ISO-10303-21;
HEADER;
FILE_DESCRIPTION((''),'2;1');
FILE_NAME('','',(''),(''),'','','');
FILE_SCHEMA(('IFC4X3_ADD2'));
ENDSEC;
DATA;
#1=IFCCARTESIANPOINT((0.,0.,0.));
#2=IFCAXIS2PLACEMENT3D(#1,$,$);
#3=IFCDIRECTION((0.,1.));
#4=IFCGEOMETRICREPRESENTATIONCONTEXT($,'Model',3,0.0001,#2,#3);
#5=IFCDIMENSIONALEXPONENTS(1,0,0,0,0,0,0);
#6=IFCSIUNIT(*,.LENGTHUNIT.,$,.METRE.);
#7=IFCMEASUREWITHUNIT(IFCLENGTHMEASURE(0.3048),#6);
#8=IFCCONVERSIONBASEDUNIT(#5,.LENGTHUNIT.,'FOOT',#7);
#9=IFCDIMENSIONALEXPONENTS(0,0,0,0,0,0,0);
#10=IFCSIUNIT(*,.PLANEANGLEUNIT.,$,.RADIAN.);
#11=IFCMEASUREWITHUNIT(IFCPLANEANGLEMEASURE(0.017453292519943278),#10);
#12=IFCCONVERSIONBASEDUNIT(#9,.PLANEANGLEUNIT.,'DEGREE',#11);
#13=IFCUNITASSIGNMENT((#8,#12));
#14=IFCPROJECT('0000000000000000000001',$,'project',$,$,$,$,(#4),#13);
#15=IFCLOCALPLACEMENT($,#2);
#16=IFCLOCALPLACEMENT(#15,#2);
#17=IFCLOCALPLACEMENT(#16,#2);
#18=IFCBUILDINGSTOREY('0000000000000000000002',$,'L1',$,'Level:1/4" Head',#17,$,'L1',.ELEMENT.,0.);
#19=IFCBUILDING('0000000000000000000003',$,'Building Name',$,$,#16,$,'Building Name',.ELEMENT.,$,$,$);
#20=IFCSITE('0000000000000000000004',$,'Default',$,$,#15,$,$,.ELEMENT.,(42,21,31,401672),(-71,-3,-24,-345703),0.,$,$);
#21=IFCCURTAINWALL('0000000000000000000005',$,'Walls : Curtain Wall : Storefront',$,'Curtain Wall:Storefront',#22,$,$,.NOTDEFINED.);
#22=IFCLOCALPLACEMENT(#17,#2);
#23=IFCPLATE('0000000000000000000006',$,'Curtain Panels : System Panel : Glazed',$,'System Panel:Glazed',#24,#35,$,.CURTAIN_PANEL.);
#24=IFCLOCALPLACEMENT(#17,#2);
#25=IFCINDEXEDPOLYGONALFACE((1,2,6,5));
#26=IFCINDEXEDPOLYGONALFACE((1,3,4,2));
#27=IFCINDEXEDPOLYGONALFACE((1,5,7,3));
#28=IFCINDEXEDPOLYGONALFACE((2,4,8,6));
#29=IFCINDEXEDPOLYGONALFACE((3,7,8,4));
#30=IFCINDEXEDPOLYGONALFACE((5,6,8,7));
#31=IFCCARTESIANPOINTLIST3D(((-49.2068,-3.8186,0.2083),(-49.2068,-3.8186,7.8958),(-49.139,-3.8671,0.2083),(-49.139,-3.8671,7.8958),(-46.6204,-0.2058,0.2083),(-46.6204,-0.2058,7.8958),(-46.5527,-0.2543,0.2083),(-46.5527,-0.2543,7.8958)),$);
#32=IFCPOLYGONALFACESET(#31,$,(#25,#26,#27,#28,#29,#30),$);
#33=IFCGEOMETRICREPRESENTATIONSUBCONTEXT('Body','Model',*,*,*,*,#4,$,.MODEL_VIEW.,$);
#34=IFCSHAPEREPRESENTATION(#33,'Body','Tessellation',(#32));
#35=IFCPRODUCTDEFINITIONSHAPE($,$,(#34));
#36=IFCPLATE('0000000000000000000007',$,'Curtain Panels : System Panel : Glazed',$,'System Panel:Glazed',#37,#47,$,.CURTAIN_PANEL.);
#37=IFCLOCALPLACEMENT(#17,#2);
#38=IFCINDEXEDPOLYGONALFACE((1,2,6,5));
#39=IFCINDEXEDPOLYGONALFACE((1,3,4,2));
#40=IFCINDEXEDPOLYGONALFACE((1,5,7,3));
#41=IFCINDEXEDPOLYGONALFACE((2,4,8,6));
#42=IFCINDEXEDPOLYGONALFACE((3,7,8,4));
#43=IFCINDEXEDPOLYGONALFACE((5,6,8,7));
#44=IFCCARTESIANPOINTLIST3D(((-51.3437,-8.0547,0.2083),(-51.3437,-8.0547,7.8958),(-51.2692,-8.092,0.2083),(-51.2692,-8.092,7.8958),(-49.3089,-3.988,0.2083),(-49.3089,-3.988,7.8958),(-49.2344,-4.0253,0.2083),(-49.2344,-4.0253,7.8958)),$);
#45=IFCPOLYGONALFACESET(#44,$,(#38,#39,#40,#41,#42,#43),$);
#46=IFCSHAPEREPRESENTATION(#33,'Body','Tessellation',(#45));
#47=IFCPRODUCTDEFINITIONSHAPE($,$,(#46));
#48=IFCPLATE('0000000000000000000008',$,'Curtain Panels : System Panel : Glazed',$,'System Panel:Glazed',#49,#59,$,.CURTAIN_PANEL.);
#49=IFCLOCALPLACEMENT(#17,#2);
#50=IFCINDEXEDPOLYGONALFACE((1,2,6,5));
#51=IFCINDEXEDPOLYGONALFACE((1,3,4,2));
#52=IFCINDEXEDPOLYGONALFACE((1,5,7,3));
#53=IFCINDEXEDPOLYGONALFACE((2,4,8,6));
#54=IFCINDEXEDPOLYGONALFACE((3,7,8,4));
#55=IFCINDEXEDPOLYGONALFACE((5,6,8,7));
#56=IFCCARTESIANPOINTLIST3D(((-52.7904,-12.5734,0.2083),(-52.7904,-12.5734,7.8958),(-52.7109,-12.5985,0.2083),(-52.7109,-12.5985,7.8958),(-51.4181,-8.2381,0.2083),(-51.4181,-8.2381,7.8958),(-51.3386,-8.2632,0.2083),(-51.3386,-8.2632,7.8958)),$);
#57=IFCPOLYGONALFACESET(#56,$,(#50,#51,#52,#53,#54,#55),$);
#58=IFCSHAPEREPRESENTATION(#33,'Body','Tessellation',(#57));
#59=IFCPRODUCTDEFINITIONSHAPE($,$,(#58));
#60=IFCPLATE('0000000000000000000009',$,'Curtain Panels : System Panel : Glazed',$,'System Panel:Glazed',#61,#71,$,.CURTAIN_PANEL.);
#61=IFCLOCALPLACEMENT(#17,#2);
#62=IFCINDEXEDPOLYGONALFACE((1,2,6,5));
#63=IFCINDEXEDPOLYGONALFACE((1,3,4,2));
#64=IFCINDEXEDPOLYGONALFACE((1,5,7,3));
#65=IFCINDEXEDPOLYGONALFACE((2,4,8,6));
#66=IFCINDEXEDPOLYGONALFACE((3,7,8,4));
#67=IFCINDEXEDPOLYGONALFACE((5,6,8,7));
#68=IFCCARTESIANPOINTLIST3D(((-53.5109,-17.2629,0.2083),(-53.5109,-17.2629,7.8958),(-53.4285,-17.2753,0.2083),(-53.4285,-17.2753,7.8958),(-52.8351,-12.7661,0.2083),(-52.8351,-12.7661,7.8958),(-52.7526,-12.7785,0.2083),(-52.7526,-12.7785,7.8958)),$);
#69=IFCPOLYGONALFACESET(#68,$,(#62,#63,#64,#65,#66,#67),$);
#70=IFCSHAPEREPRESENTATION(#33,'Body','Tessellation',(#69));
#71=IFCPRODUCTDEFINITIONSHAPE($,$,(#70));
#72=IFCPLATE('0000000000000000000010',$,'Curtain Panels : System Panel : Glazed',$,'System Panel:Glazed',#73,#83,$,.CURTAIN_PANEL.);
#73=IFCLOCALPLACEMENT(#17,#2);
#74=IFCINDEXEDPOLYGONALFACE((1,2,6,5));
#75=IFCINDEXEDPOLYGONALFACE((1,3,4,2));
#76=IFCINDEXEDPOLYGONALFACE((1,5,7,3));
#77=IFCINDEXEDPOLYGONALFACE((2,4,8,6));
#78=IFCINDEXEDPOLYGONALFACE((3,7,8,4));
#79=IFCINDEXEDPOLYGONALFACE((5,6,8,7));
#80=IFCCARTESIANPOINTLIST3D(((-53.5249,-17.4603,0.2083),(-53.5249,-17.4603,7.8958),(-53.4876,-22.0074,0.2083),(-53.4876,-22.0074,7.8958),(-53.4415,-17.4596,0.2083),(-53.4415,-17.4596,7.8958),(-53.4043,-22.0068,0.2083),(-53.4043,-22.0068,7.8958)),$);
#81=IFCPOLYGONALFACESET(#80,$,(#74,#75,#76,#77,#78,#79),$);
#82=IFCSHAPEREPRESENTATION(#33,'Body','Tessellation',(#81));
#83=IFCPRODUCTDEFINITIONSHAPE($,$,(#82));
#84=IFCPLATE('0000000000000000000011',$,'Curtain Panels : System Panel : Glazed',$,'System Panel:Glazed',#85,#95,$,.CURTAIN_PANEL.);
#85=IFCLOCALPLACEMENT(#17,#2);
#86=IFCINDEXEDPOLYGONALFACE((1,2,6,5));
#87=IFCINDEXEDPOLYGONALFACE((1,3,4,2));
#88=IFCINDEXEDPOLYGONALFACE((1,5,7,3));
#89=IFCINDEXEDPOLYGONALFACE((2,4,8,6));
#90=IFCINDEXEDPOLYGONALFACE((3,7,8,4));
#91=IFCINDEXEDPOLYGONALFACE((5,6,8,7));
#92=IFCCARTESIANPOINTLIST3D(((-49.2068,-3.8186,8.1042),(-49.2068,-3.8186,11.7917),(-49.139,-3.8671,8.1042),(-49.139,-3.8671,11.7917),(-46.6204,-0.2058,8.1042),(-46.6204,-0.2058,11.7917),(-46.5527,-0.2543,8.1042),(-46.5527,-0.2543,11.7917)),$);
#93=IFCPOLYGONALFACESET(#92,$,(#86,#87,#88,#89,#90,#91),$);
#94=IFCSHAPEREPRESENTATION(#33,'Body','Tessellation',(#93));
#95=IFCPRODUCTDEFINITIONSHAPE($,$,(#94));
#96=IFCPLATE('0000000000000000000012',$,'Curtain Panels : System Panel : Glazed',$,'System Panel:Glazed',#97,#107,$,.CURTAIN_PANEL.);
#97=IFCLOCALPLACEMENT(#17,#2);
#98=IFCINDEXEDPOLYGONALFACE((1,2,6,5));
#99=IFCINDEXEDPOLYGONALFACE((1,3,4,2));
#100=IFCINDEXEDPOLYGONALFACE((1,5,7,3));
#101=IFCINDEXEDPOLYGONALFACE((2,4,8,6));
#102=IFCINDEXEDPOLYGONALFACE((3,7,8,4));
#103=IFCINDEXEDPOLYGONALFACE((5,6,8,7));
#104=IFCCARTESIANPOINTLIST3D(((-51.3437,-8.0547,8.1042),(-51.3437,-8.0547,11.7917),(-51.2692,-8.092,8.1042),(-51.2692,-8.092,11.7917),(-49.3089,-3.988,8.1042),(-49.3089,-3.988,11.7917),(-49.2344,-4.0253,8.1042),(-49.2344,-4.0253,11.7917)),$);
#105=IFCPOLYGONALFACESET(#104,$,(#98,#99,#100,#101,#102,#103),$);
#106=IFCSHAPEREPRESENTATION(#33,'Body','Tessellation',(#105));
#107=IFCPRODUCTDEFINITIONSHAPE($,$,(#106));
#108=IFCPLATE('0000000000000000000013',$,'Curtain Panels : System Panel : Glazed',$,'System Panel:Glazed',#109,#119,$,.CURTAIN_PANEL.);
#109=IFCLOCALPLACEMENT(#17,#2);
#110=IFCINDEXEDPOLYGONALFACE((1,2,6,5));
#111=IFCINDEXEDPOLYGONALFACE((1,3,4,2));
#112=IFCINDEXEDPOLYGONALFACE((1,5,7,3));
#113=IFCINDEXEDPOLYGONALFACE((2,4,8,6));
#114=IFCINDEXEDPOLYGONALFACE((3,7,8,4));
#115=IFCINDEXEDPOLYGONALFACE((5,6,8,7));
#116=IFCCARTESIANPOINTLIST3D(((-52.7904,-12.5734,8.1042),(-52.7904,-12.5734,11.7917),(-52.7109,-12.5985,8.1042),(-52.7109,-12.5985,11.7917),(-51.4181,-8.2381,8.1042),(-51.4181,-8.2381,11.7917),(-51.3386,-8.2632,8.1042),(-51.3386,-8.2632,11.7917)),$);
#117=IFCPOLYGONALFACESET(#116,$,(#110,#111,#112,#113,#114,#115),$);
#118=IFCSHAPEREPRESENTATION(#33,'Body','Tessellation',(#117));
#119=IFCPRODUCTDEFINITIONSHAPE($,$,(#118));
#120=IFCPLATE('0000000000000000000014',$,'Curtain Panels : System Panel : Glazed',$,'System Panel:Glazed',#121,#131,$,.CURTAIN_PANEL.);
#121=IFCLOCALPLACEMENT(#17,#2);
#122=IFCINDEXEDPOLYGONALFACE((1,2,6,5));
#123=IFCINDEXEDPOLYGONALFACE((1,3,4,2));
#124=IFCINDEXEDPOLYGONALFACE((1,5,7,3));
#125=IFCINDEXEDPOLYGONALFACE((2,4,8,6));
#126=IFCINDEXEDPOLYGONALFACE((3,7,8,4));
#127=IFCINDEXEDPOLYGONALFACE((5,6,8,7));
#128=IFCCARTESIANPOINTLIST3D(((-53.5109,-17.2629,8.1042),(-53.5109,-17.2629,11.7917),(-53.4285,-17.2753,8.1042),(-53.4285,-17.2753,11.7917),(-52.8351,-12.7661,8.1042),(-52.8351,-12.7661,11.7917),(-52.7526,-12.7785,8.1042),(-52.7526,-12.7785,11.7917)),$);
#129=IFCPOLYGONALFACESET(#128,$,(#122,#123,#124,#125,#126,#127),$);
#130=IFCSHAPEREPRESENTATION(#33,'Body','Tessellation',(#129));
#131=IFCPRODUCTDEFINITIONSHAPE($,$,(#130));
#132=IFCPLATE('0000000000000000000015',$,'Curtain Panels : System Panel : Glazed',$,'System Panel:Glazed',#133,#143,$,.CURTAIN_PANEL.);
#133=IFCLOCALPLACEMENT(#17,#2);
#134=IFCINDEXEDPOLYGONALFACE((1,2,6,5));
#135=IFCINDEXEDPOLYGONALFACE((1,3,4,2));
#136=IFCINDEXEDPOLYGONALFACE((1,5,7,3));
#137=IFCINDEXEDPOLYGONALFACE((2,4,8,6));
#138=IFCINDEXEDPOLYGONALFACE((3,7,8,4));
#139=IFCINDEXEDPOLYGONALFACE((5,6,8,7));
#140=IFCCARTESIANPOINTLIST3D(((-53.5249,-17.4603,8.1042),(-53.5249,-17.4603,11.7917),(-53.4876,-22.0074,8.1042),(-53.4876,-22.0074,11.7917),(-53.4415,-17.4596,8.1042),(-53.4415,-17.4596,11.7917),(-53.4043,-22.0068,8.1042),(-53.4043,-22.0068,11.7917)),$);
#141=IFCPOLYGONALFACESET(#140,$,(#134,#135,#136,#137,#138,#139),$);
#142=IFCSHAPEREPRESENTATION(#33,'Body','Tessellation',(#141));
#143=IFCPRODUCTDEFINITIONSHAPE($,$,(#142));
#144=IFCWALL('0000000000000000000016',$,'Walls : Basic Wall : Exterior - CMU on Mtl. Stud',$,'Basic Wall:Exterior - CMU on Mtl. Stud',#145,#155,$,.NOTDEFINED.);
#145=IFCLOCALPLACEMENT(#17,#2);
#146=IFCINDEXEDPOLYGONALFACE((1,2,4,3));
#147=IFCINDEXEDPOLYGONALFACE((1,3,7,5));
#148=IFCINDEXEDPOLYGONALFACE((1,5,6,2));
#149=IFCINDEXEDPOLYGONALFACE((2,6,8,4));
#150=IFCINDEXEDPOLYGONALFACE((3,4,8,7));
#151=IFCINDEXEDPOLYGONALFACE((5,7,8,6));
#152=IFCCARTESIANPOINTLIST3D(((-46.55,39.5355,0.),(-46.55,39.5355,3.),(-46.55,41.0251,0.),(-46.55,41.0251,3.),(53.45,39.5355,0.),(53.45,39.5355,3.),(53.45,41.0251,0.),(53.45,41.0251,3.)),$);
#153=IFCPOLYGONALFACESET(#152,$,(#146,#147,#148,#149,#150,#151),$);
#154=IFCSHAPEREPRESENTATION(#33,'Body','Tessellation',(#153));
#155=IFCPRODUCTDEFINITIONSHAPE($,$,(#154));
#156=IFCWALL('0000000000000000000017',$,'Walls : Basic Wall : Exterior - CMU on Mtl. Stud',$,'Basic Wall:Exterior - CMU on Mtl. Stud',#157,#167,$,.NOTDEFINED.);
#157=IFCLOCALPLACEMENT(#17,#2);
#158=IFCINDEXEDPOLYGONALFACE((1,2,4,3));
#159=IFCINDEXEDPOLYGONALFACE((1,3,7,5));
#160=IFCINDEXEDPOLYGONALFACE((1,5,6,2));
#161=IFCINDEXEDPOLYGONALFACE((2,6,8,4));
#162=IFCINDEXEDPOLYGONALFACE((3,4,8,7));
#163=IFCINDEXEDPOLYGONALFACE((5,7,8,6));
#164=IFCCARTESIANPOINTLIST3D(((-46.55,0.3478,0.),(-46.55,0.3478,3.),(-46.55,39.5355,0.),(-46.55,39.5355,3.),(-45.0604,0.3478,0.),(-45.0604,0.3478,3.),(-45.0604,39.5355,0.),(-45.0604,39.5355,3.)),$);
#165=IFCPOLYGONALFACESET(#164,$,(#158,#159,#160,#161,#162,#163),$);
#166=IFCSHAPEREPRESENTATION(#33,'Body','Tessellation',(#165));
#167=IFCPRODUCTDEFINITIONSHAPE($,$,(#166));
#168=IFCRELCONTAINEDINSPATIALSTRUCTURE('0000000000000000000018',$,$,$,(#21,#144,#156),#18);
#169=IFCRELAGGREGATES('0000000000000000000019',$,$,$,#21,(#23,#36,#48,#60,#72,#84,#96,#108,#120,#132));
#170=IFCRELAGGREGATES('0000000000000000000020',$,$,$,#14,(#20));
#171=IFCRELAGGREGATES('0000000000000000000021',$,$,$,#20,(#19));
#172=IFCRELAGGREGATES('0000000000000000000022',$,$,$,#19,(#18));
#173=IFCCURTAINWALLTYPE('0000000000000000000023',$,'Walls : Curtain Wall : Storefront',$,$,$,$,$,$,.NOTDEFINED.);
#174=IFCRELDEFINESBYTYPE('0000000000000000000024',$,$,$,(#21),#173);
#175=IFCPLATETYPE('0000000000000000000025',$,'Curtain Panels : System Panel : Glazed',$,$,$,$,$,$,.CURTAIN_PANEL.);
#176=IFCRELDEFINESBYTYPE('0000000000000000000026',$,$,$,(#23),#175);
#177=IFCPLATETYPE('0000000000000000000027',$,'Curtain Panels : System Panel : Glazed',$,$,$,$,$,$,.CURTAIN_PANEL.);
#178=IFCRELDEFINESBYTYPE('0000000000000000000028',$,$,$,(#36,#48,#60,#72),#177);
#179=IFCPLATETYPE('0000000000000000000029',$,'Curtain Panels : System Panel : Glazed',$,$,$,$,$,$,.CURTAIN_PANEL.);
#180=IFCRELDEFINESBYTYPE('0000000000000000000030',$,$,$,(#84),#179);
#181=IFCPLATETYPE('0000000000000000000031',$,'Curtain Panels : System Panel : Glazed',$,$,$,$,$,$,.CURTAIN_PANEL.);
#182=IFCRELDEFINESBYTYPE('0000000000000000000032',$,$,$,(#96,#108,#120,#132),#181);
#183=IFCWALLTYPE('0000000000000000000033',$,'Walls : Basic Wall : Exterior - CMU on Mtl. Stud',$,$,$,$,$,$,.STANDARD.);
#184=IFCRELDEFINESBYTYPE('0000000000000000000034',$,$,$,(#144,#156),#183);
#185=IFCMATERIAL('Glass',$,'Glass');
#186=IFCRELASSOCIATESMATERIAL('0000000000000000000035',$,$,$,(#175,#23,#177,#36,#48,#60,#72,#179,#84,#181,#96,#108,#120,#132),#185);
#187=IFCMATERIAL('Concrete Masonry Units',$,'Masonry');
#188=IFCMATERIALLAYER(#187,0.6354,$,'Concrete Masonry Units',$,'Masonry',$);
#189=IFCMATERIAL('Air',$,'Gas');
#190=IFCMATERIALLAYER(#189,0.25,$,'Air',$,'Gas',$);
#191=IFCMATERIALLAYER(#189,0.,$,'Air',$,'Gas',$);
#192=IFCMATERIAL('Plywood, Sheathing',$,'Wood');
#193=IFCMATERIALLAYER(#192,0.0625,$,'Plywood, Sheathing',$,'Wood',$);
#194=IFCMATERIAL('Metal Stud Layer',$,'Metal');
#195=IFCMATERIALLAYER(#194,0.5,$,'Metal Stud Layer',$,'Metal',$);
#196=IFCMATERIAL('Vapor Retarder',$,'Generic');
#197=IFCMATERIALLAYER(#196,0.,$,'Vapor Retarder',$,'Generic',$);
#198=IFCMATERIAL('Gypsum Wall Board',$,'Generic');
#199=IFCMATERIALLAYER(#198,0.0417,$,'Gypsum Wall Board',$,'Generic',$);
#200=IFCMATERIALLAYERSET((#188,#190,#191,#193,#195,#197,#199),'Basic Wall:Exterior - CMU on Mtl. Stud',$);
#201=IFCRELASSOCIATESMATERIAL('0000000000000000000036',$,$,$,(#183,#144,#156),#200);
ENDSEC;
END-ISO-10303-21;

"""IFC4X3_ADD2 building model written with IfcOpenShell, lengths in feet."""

from ifc_helpers import new_model, entity, si_unit, converted_unit, direction, frame, frame_2d, origin, place, context, subcontext, project, spatial, rectangle, extrude, source, transform, mapped, material, layer, layer_set, type_object, type_shapes, element, aggregate, save


model = new_model("IFC4X3_ADD2")

# Units and contexts
model_context = context("Model", 3, precision=0.0001, world=origin(), true_north=direction((0.0, 1.0)))
body_context = subcontext(model_context, "Body", "Model", "MODEL_VIEW")
ifc_project = project(units=[converted_unit("LENGTHUNIT", "FOOT", entity("IfcLengthMeasure", 0.3048), si_unit("LENGTHUNIT", "METRE"), dimensions=[1, 0, 0, 0, 0, 0, 0]), converted_unit("PLANEANGLEUNIT", "DEGREE", entity("IfcPlaneAngleMeasure", 0.017453292519943278), si_unit("PLANEANGLEUNIT", "RADIAN"), dimensions=[0, 0, 0, 0, 0, 0, 0])], contexts=[model_context])

# Site, building, storey
site_placement = place(None, origin())
site = spatial("IfcSite", under=ifc_project, at=site_placement, Name="Default", CompositionType="ELEMENT", RefLatitude=(42, 21, 31, 401672), RefLongitude=(-71, -3, -24, -345703), RefElevation=0.0)
building_placement = place(site_placement, origin())
building = spatial("IfcBuilding", under=site, at=building_placement, Name="Building Name", LongName="Building Name", CompositionType="ELEMENT")
storey_placement = place(building_placement, origin())
storey = spatial("IfcBuildingStorey", under=building, at=storey_placement, Name="L1", ObjectType="Level:1/4\" Head", LongName="L1", CompositionType="ELEMENT", Elevation=0.0)

# Curtain wall, plates
curtain_wall_type = type_object("IfcCurtainWallType", Name="Walls : Curtain Wall : Storefront", PredefinedType="NOTDEFINED")
curtain_wall_placement = place(storey_placement, origin())
curtain_wall = element("IfcCurtainWall", 1, at=curtain_wall_placement, inside=storey, type_object=curtain_wall_type, Name="Walls : Curtain Wall : Storefront", ObjectType="Curtain Wall:Storefront", PredefinedType="NOTDEFINED")
ifc_material_1 = material(Name="Glass", Category="Glass")
plate_type_1 = type_object("IfcPlateType", Name="Curtain Panels : System Panel : Glazed", PredefinedType="CURTAIN_PANEL", material=ifc_material_1)
shared_shape_1 = source(origin(), body_context, "Body", "SweptSolid", [
    extrude(rectangle(XDim=0.0833, YDim=4.4431, at=frame_2d((0.0, 0.0), x_axis=(1.0, 0.0))), frame((2.2216, 0.0417, 0.0), z_axis=(0.0, 0.0, 1.0), x_axis=(0.0, 1.0, 0.0)), (0.0, 0.0, 1.0), 7.6875),
])
type_shapes(plate_type_1, [shared_shape_1])
plate_1_placement = place(curtain_wall_placement, frame((-46.6204, -0.2058, 0.2083), z_axis=(0.0, 0.0, 1.0), x_axis=(-0.582096, -0.81312, 0.0)))
plate_1 = element("IfcPlate", 2, at=plate_1_placement, type_object=plate_type_1, material=ifc_material_1, Name="Curtain Panels : System Panel : Glazed", ObjectType="System Panel:Glazed", PredefinedType="CURTAIN_PANEL", context=body_context, shape_type="MappedRepresentation", body=[
    mapped(shared_shape_1, transform((0.0, 0.0, 0.0), scale=1.0)),
])
plate_type_2 = type_object("IfcPlateType", Name="Curtain Panels : System Panel : Glazed", PredefinedType="CURTAIN_PANEL", material=ifc_material_1)
shared_shape_2 = source(origin(), body_context, "Body", "SweptSolid", [
    extrude(rectangle(XDim=0.0833, YDim=4.5473, at=frame_2d((0.0, 0.0), x_axis=(1.0, 0.0))), frame((2.2737, 0.0417, 0.0), z_axis=(0.0, 0.0, 1.0), x_axis=(0.0, 1.0, 0.0)), (0.0, 0.0, 1.0), 7.6875),
])
type_shapes(plate_type_2, [shared_shape_2])
plate_2_placement = place(curtain_wall_placement, frame((-49.3089, -3.988, 0.2083), z_axis=(0.0, 0.0, 1.0), x_axis=(-0.447467, -0.8943, 0.0)))
plate_2 = element("IfcPlate", 3, at=plate_2_placement, type_object=plate_type_2, material=ifc_material_1, Name="Curtain Panels : System Panel : Glazed", ObjectType="System Panel:Glazed", PredefinedType="CURTAIN_PANEL", context=body_context, shape_type="MappedRepresentation", body=[
    mapped(shared_shape_2, transform((0.0, 0.0, 0.0), scale=1.0)),
])
plate_3_placement = place(curtain_wall_placement, frame((-51.4181, -8.2381, 0.2083), z_axis=(0.0, 0.0, 1.0), x_axis=(-0.301779, -0.953378, 0.0)))
plate_3 = element("IfcPlate", 4, at=plate_3_placement, type_object=plate_type_2, material=ifc_material_1, Name="Curtain Panels : System Panel : Glazed", ObjectType="System Panel:Glazed", PredefinedType="CURTAIN_PANEL", context=body_context, shape_type="MappedRepresentation", body=[
    mapped(shared_shape_2, transform((0.0, 0.0, 0.0), scale=1.0)),
])
plate_4_placement = place(curtain_wall_placement, frame((-52.8351, -12.7661, 0.2083), z_axis=(0.0, 0.0, 1.0), x_axis=(-0.148632, -0.988893, 0.0)))
plate_4 = element("IfcPlate", 5, at=plate_4_placement, type_object=plate_type_2, material=ifc_material_1, Name="Curtain Panels : System Panel : Glazed", ObjectType="System Panel:Glazed", PredefinedType="CURTAIN_PANEL", context=body_context, shape_type="MappedRepresentation", body=[
    mapped(shared_shape_2, transform((0.0, 0.0, 0.0), scale=1.0)),
])
plate_5_placement = place(curtain_wall_placement, frame((-53.5249, -17.4603, 0.2083), z_axis=(0.0, 0.0, 1.0), x_axis=(0.008188, -0.999966, 0.0)))
plate_5 = element("IfcPlate", 6, at=plate_5_placement, type_object=plate_type_2, material=ifc_material_1, Name="Curtain Panels : System Panel : Glazed", ObjectType="System Panel:Glazed", PredefinedType="CURTAIN_PANEL", context=body_context, shape_type="MappedRepresentation", body=[
    mapped(shared_shape_2, transform((0.0, 0.0, 0.0), scale=1.0)),
])
plate_type_3 = type_object("IfcPlateType", Name="Curtain Panels : System Panel : Glazed", PredefinedType="CURTAIN_PANEL", material=ifc_material_1)
shared_shape_3 = source(origin(), body_context, "Body", "SweptSolid", [
    extrude(rectangle(XDim=0.0833, YDim=4.4431, at=frame_2d((0.0, 0.0), x_axis=(1.0, 0.0))), frame((2.2216, 0.0417, 0.0), z_axis=(0.0, 0.0, 1.0), x_axis=(0.0, 1.0, 0.0)), (0.0, 0.0, 1.0), 3.6875),
])
type_shapes(plate_type_3, [shared_shape_3])
plate_6_placement = place(curtain_wall_placement, frame((-46.6204, -0.2058, 8.1042), z_axis=(0.0, 0.0, 1.0), x_axis=(-0.582096, -0.81312, 0.0)))
plate_6 = element("IfcPlate", 7, at=plate_6_placement, type_object=plate_type_3, material=ifc_material_1, Name="Curtain Panels : System Panel : Glazed", ObjectType="System Panel:Glazed", PredefinedType="CURTAIN_PANEL", context=body_context, shape_type="MappedRepresentation", body=[
    mapped(shared_shape_3, transform((0.0, 0.0, 0.0), scale=1.0)),
])
plate_type_4 = type_object("IfcPlateType", Name="Curtain Panels : System Panel : Glazed", PredefinedType="CURTAIN_PANEL", material=ifc_material_1)
shared_shape_4 = source(origin(), body_context, "Body", "SweptSolid", [
    extrude(rectangle(XDim=0.0833, YDim=4.5473, at=frame_2d((0.0, 0.0), x_axis=(1.0, 0.0))), frame((2.2737, 0.0417, 0.0), z_axis=(0.0, 0.0, 1.0), x_axis=(0.0, 1.0, 0.0)), (0.0, 0.0, 1.0), 3.6875),
])
type_shapes(plate_type_4, [shared_shape_4])
plate_7_placement = place(curtain_wall_placement, frame((-49.3089, -3.988, 8.1042), z_axis=(0.0, 0.0, 1.0), x_axis=(-0.447467, -0.8943, 0.0)))
plate_7 = element("IfcPlate", 8, at=plate_7_placement, type_object=plate_type_4, material=ifc_material_1, Name="Curtain Panels : System Panel : Glazed", ObjectType="System Panel:Glazed", PredefinedType="CURTAIN_PANEL", context=body_context, shape_type="MappedRepresentation", body=[
    mapped(shared_shape_4, transform((0.0, 0.0, 0.0), scale=1.0)),
])
plate_8_placement = place(curtain_wall_placement, frame((-51.4181, -8.2381, 8.1042), z_axis=(0.0, 0.0, 1.0), x_axis=(-0.301779, -0.953378, 0.0)))
plate_8 = element("IfcPlate", 9, at=plate_8_placement, type_object=plate_type_4, material=ifc_material_1, Name="Curtain Panels : System Panel : Glazed", ObjectType="System Panel:Glazed", PredefinedType="CURTAIN_PANEL", context=body_context, shape_type="MappedRepresentation", body=[
    mapped(shared_shape_4, transform((0.0, 0.0, 0.0), scale=1.0)),
])
plate_9_placement = place(curtain_wall_placement, frame((-52.8351, -12.7661, 8.1042), z_axis=(0.0, 0.0, 1.0), x_axis=(-0.148632, -0.988893, 0.0)))
plate_9 = element("IfcPlate", 10, at=plate_9_placement, type_object=plate_type_4, material=ifc_material_1, Name="Curtain Panels : System Panel : Glazed", ObjectType="System Panel:Glazed", PredefinedType="CURTAIN_PANEL", context=body_context, shape_type="MappedRepresentation", body=[
    mapped(shared_shape_4, transform((0.0, 0.0, 0.0), scale=1.0)),
])
plate_10_placement = place(curtain_wall_placement, frame((-53.5249, -17.4603, 8.1042), z_axis=(0.0, 0.0, 1.0), x_axis=(0.008188, -0.999966, 0.0)))
plate_10 = element("IfcPlate", 11, at=plate_10_placement, type_object=plate_type_4, material=ifc_material_1, Name="Curtain Panels : System Panel : Glazed", ObjectType="System Panel:Glazed", PredefinedType="CURTAIN_PANEL", context=body_context, shape_type="MappedRepresentation", body=[
    mapped(shared_shape_4, transform((0.0, 0.0, 0.0), scale=1.0)),
])
aggregate(curtain_wall, [plate_1, plate_2, plate_3, plate_4, plate_5, plate_6, plate_7, plate_8, plate_9, plate_10])

# Walls
ifc_material_2 = material(Name="Concrete Masonry Units", Category="Masonry")
ifc_layer_1 = layer(ifc_material_2, 0.6354, Name="Concrete Masonry Units", Category="Masonry")
ifc_material_3 = material(Name="Air", Category="Gas")
ifc_layer_2 = layer(ifc_material_3, 0.25, Name="Air", Category="Gas")
ifc_layer_3 = layer(ifc_material_3, 0.0, Name="Air", Category="Gas")
ifc_material_4 = material(Name="Plywood, Sheathing", Category="Wood")
ifc_layer_4 = layer(ifc_material_4, 0.0625, Name="Plywood, Sheathing", Category="Wood")
ifc_material_5 = material(Name="Metal Stud Layer", Category="Metal")
ifc_layer_5 = layer(ifc_material_5, 0.5, Name="Metal Stud Layer", Category="Metal")
ifc_material_6 = material(Name="Vapor Retarder", Category="Generic")
ifc_layer_6 = layer(ifc_material_6, 0.0, Name="Vapor Retarder", Category="Generic")
ifc_material_7 = material(Name="Gypsum Wall Board", Category="Generic")
ifc_layer_7 = layer(ifc_material_7, 0.0417, Name="Gypsum Wall Board", Category="Generic")
ifc_layer_set_1 = layer_set([ifc_layer_1, ifc_layer_2, ifc_layer_3, ifc_layer_4, ifc_layer_5, ifc_layer_6, ifc_layer_7], Name="Basic Wall:Exterior - CMU on Mtl. Stud")
wall_type_1 = type_object("IfcWallType", Name="Walls : Basic Wall : Exterior - CMU on Mtl. Stud", PredefinedType="STANDARD", material=ifc_layer_set_1)
wall_1_placement = place(storey_placement, frame((-46.55, 40.2803, 0.0)))
element("IfcWall", 12, at=wall_1_placement, inside=storey, type_object=wall_type_1, material=ifc_layer_set_1, Name="Walls : Basic Wall : Exterior - CMU on Mtl. Stud", ObjectType="Basic Wall:Exterior - CMU on Mtl. Stud", PredefinedType="NOTDEFINED", context=body_context, shape_type="SweptSolid", body=[
    extrude(rectangle(XDim=100.0, YDim=1.4896, at=frame_2d((50.0, 0.0), x_axis=(-1.0, 0.0))), origin(), (0.0, 0.0, 1.0), 3.0),
])
wall_2_placement = place(storey_placement, frame((-45.8052, 0.3478, 0.0), z_axis=(0.0, 0.0, 1.0), x_axis=(0.0, 1.0, 0.0)))
element("IfcWall", 13, at=wall_2_placement, inside=storey, type_object=wall_type_1, material=ifc_layer_set_1, Name="Walls : Basic Wall : Exterior - CMU on Mtl. Stud", ObjectType="Basic Wall:Exterior - CMU on Mtl. Stud", PredefinedType="NOTDEFINED", context=body_context, shape_type="SweptSolid", body=[
    extrude(rectangle(XDim=39.1877, YDim=1.4896, at=frame_2d((19.5939, 0.0), x_axis=(-1.0, 0.0))), origin(), (0.0, 0.0, 1.0), 3.0),
])

save(model, "model.ifc")
